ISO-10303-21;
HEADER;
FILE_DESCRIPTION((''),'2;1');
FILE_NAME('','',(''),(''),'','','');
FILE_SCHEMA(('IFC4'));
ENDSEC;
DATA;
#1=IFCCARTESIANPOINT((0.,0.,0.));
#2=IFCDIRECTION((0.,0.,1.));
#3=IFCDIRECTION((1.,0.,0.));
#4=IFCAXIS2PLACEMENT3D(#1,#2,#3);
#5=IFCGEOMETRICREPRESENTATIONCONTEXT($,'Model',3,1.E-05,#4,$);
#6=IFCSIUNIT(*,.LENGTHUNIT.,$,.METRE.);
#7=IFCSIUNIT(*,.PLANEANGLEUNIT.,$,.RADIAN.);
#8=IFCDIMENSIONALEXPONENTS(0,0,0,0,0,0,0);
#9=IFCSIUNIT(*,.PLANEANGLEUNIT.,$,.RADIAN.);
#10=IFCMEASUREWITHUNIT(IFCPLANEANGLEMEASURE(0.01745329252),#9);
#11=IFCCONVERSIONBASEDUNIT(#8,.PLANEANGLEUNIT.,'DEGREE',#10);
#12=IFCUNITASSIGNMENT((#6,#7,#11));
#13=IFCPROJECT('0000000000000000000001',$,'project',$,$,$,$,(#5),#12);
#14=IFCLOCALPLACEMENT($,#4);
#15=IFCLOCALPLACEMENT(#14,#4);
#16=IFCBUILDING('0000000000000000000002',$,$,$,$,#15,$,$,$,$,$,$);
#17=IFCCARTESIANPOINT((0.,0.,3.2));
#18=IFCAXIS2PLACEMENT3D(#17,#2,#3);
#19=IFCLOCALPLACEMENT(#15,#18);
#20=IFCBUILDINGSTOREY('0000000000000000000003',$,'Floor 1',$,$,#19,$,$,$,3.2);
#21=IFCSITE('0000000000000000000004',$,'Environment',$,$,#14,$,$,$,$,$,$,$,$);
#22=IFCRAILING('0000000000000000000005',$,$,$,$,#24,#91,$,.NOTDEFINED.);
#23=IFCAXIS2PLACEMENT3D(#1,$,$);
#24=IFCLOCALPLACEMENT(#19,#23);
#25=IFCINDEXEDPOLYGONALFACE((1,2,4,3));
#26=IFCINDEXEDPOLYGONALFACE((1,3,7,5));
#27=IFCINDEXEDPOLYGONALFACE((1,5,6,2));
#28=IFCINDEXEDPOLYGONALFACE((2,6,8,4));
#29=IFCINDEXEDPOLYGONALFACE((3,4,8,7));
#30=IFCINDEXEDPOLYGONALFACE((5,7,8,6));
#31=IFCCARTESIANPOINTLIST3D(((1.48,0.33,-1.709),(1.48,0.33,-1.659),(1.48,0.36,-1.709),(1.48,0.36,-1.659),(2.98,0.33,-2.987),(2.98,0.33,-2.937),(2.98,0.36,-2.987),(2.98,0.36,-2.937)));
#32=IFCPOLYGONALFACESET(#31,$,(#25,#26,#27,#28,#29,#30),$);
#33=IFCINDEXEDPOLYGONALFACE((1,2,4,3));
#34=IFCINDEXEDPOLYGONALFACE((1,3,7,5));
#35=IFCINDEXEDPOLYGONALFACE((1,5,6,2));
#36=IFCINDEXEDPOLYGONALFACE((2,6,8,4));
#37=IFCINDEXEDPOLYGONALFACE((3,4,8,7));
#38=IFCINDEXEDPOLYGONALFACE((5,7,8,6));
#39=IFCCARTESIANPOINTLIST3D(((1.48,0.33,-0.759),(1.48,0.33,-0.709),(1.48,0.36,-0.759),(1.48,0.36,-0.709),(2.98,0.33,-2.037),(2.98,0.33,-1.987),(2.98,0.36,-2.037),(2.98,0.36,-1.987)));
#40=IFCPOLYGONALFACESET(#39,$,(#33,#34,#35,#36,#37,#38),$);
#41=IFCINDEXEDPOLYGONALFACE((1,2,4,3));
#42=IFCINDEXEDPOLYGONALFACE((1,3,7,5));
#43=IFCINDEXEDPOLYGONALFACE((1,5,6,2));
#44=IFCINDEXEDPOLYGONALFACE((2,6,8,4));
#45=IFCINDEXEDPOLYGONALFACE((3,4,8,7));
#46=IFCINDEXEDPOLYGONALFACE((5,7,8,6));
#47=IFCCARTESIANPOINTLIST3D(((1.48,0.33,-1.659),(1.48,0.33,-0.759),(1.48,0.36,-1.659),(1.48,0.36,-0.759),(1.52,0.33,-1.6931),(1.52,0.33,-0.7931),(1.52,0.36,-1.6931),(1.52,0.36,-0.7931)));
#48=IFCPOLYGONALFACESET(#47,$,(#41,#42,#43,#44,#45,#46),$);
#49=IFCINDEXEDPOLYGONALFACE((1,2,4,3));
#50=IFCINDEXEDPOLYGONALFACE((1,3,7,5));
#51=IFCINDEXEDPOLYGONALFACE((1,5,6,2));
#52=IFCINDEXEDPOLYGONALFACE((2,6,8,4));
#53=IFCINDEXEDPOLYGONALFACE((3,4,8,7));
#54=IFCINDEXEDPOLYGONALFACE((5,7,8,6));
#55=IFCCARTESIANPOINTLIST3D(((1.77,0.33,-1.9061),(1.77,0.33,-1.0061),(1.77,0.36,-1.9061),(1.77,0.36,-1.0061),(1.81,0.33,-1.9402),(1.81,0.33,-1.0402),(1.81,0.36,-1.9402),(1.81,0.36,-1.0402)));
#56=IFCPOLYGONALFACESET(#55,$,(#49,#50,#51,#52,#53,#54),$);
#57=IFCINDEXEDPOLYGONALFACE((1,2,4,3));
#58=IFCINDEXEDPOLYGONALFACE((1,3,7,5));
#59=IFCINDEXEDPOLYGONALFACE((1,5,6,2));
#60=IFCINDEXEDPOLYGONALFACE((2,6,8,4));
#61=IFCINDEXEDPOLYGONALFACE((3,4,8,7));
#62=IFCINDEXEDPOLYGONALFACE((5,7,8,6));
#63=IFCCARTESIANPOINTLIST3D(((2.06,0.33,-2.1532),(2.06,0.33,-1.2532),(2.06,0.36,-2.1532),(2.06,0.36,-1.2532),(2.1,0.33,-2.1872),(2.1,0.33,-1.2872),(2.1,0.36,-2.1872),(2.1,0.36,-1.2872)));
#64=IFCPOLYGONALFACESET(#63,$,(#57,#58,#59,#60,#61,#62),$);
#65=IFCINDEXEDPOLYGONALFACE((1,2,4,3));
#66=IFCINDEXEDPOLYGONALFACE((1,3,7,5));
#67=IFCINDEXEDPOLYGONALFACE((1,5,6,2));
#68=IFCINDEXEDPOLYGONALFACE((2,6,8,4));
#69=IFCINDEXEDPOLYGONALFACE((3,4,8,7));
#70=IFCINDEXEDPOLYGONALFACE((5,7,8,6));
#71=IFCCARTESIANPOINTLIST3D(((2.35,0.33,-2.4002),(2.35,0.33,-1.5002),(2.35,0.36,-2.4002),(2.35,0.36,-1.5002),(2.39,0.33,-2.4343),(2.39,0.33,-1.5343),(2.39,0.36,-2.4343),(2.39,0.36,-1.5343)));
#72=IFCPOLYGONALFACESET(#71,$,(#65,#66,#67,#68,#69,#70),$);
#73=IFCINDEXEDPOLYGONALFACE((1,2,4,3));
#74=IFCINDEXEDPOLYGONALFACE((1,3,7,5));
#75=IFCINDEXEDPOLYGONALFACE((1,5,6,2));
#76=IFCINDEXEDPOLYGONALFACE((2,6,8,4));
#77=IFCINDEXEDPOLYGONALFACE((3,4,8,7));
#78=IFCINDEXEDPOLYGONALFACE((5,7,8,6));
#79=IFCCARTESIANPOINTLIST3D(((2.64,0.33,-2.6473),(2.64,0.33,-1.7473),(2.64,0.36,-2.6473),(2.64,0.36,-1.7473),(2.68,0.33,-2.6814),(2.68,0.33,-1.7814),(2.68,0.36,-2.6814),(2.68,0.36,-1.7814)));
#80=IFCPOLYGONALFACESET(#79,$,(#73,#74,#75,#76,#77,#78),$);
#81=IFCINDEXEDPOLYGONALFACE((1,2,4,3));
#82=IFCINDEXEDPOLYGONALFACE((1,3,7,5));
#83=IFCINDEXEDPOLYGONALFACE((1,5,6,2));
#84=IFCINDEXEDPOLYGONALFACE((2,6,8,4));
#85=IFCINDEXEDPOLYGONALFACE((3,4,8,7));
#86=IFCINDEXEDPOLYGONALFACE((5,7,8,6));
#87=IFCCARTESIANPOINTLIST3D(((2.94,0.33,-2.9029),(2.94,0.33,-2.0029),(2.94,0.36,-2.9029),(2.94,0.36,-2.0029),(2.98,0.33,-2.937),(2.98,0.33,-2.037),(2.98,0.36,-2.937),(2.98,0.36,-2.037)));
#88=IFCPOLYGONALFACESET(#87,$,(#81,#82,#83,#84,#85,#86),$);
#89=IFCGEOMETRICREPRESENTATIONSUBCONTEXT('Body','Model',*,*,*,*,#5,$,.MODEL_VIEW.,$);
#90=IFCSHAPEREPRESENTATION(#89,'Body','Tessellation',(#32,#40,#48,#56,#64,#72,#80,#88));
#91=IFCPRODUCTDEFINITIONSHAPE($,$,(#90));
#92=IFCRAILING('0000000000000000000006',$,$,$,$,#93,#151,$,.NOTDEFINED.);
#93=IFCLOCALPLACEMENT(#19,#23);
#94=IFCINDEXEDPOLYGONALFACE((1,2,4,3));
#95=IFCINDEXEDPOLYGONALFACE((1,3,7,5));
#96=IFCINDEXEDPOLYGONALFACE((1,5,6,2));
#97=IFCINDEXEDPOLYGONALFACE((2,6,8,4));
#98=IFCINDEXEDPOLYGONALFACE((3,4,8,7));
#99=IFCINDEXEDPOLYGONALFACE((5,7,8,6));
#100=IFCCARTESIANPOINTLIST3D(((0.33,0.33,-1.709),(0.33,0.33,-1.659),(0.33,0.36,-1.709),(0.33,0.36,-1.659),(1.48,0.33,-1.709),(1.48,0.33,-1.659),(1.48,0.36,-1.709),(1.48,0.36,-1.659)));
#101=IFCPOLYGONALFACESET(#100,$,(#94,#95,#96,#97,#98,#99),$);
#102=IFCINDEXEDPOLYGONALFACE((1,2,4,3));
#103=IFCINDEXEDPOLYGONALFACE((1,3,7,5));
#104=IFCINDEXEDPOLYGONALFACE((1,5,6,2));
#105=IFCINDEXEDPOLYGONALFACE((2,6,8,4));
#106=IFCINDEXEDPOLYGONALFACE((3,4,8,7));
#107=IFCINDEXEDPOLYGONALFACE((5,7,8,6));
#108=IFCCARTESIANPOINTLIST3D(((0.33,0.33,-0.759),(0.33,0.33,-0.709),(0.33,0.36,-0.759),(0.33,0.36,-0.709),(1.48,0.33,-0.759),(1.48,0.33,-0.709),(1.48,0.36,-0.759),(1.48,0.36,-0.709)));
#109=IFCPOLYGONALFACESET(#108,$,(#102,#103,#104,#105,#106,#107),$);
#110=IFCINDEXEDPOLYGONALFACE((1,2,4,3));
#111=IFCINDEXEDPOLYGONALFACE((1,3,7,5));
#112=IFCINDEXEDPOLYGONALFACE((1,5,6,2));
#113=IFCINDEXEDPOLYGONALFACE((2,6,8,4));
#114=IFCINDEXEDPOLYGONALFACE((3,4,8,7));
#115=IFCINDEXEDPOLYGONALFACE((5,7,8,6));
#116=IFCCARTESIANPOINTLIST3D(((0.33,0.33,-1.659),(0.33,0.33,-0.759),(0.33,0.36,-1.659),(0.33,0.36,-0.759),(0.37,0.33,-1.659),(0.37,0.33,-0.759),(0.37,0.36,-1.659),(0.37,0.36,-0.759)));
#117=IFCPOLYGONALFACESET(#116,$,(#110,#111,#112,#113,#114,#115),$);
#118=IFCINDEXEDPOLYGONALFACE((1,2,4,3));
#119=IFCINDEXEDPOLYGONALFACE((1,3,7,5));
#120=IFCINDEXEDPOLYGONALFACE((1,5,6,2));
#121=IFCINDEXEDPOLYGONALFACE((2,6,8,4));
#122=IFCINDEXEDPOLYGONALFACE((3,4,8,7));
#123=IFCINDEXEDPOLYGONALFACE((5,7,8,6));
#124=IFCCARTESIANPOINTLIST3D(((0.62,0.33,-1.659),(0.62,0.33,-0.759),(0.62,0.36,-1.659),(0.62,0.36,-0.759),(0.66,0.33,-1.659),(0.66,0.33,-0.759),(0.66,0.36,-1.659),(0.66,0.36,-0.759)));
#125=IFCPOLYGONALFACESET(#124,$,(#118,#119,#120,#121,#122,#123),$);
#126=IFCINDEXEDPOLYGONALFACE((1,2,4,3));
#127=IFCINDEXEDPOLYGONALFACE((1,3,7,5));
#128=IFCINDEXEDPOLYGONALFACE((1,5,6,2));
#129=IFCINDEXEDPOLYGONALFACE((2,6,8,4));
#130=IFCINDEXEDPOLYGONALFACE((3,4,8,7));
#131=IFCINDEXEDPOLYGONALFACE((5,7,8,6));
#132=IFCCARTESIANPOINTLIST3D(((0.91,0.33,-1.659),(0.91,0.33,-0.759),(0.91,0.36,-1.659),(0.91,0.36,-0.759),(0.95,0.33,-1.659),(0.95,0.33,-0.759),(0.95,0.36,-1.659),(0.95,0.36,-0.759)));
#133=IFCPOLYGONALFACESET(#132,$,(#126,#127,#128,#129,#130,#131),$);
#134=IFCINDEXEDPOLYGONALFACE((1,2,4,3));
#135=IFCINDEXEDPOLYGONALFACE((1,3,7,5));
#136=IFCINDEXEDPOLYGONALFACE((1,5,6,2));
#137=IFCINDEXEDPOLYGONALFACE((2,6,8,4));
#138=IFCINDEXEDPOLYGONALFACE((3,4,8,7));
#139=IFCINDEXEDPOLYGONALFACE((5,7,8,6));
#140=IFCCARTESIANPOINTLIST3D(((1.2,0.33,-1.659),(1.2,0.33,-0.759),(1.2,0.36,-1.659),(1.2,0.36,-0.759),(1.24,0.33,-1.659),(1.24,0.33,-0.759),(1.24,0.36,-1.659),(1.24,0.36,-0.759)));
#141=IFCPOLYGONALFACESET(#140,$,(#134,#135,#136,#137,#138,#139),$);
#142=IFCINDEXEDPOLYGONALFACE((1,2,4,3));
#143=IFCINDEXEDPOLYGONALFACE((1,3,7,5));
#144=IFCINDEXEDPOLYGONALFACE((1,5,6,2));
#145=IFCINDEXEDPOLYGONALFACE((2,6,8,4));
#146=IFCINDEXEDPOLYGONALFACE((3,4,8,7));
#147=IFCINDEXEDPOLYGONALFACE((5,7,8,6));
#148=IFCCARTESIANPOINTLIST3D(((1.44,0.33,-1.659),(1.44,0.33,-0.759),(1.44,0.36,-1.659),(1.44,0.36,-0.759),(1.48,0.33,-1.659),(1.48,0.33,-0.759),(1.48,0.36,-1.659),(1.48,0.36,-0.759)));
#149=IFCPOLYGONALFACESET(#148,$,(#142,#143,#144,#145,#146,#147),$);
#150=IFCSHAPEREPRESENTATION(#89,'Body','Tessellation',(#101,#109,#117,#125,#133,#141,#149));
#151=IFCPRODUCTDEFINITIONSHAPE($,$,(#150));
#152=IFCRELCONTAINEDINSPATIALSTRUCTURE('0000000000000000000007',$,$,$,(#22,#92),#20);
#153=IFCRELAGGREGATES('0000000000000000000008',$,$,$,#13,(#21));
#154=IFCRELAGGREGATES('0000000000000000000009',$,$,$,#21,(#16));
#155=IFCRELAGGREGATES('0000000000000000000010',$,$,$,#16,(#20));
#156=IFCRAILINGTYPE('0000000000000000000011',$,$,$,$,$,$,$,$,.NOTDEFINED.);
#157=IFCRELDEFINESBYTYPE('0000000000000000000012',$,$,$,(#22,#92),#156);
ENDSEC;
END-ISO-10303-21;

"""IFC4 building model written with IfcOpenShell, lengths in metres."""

from ifc_helpers import new_model, entity, si_unit, converted_unit, frame, origin_with_axes, place, context, subcontext, project, spatial, polyline, outline, extrude, type_object, element, save


model = new_model("IFC4")

# Units and contexts
model_context = context("Model", 3, precision=1e-05, world=origin_with_axes())
body_context = subcontext(model_context, "Body", "Model", "MODEL_VIEW")
ifc_project = project(units=[si_unit("LENGTHUNIT", "METRE"), si_unit("PLANEANGLEUNIT", "RADIAN"), converted_unit("PLANEANGLEUNIT", "DEGREE", entity("IfcPlaneAngleMeasure", 0.01745329252), si_unit("PLANEANGLEUNIT", "RADIAN"), dimensions=[0, 0, 0, 0, 0, 0, 0])], contexts=[model_context])

# Site, building, storey
site_placement = place(None, origin_with_axes())
site = spatial("IfcSite", under=ifc_project, at=site_placement, Name="Environment")
building_placement = place(site_placement, origin_with_axes())
building = spatial("IfcBuilding", under=site, at=building_placement)
storey_placement = place(building_placement, frame((0.0, 0.0, 3.2), z_axis=(0.0, 0.0, 1.0), x_axis=(1.0, 0.0, 0.0)))
storey = spatial("IfcBuildingStorey", under=building, at=storey_placement, Name="Floor 1", Elevation=3.2)

# Railings
railing_type = type_object("IfcRailingType", PredefinedType="NOTDEFINED")
railing_1_placement = place(storey_placement, frame((1.48, 0.33, -1.709), z_axis=(0.0, 0.0, 1.0), x_axis=(1.0, 0.0, 0.0)))
element("IfcRailing", 1, at=railing_1_placement, inside=storey, type_object=railing_type, PredefinedType="NOTDEFINED", context=body_context, shape_type="MappedRepresentation", body=[
    extrude(outline(polyline([(0.0, 0.0), (1.5, -1.278), (1.5, -1.228), (0.0, 0.05), (0.0, 0.0)])), frame((0.0, 0.03, 0.0), z_axis=(0.0, -1.0, 0.0), x_axis=(1.0, 0.0, 0.0)), (0.0, 0.0, 1.0), 0.03),
    extrude(outline(polyline([(0.0, 0.0), (1.5, -1.278), (1.5, -1.228), (0.0, 0.05), (0.0, 0.0)])), frame((0.0, 0.03, 0.95), z_axis=(0.0, -1.0, 0.0), x_axis=(1.0, 0.0, 0.0)), (0.0, 0.0, 1.0), 0.03),
    extrude(outline(polyline([(0.0, 0.0), (0.04, -0.0341), (0.04, 0.8659), (0.0, 0.9), (0.0, 0.0)])), frame((0.0, 0.03, 0.05), z_axis=(0.0, -1.0, 0.0), x_axis=(1.0, 0.0, 0.0)), (0.0, 0.0, 1.0), 0.03),
    extrude(outline(polyline([(0.0, 0.0), (0.04, -0.0341), (0.04, 0.8659), (0.0, 0.9), (0.0, 0.0)])), frame((0.29, 0.03, -0.1971), z_axis=(0.0, -1.0, 0.0), x_axis=(1.0, 0.0, 0.0)), (0.0, 0.0, 1.0), 0.03),
    extrude(outline(polyline([(0.0, 0.0), (0.04, -0.0341), (0.04, 0.8659), (0.0, 0.9), (0.0, 0.0)])), frame((0.58, 0.03, -0.4442), z_axis=(0.0, -1.0, 0.0), x_axis=(1.0, 0.0, 0.0)), (0.0, 0.0, 1.0), 0.03),
    extrude(outline(polyline([(0.0, 0.0), (0.04, -0.0341), (0.04, 0.8659), (0.0, 0.9), (0.0, 0.0)])), frame((0.87, 0.03, -0.6912), z_axis=(0.0, -1.0, 0.0), x_axis=(1.0, 0.0, 0.0)), (0.0, 0.0, 1.0), 0.03),
    extrude(outline(polyline([(0.0, 0.0), (0.04, -0.0341), (0.04, 0.8659), (0.0, 0.9), (0.0, 0.0)])), frame((1.16, 0.03, -0.9383), z_axis=(0.0, -1.0, 0.0), x_axis=(1.0, 0.0, 0.0)), (0.0, 0.0, 1.0), 0.03),
    extrude(outline(polyline([(0.0, 0.0), (0.04, -0.0341), (0.04, 0.8659), (0.0, 0.9), (0.0, 0.0)])), frame((1.46, 0.03, -1.1939), z_axis=(0.0, -1.0, 0.0), x_axis=(1.0, 0.0, 0.0)), (0.0, 0.0, 1.0), 0.03),
])
railing_2_placement = place(storey_placement, frame((0.33, 0.33, -1.709), z_axis=(0.0, 0.0, 1.0), x_axis=(1.0, 0.0, 0.0)))
element("IfcRailing", 2, at=railing_2_placement, inside=storey, type_object=railing_type, PredefinedType="NOTDEFINED", context=body_context, shape_type="MappedRepresentation", body=[
    extrude(outline(polyline([(0.0, 0.0), (1.15, 0.0), (1.15, 0.05), (0.0, 0.05), (0.0, 0.0)])), frame((0.0, 0.03, 0.0), z_axis=(0.0, -1.0, 0.0), x_axis=(1.0, 0.0, 0.0)), (0.0, 0.0, 1.0), 0.03),
    extrude(outline(polyline([(0.0, 0.0), (1.15, 0.0), (1.15, 0.05), (0.0, 0.05), (0.0, 0.0)])), frame((0.0, 0.03, 0.95), z_axis=(0.0, -1.0, 0.0), x_axis=(1.0, 0.0, 0.0)), (0.0, 0.0, 1.0), 0.03),
    extrude(outline(polyline([(0.0, 0.0), (0.04, 0.0), (0.04, 0.9), (0.0, 0.9), (0.0, 0.0)])), frame((0.0, 0.03, 0.05), z_axis=(0.0, -1.0, 0.0), x_axis=(1.0, 0.0, 0.0)), (0.0, 0.0, 1.0), 0.03),
    extrude(outline(polyline([(0.0, 0.0), (0.04, 0.0), (0.04, 0.9), (0.0, 0.9), (0.0, 0.0)])), frame((0.29, 0.03, 0.05), z_axis=(0.0, -1.0, 0.0), x_axis=(1.0, 0.0, 0.0)), (0.0, 0.0, 1.0), 0.03),
    extrude(outline(polyline([(0.0, 0.0), (0.04, 0.0), (0.04, 0.9), (0.0, 0.9), (0.0, 0.0)])), frame((0.58, 0.03, 0.05), z_axis=(0.0, -1.0, 0.0), x_axis=(1.0, 0.0, 0.0)), (0.0, 0.0, 1.0), 0.03),
    extrude(outline(polyline([(0.0, 0.0), (0.04, 0.0), (0.04, 0.9), (0.0, 0.9), (0.0, 0.0)])), frame((0.87, 0.03, 0.05), z_axis=(0.0, -1.0, 0.0), x_axis=(1.0, 0.0, 0.0)), (0.0, 0.0, 1.0), 0.03),
    extrude(outline(polyline([(0.0, 0.0), (0.04, 0.0), (0.04, 0.9), (0.0, 0.9), (0.0, 0.0)])), frame((1.11, 0.03, 0.05), z_axis=(0.0, -1.0, 0.0), x_axis=(1.0, 0.0, 0.0)), (0.0, 0.0, 1.0), 0.03),
])

save(model, "model.ifc")
